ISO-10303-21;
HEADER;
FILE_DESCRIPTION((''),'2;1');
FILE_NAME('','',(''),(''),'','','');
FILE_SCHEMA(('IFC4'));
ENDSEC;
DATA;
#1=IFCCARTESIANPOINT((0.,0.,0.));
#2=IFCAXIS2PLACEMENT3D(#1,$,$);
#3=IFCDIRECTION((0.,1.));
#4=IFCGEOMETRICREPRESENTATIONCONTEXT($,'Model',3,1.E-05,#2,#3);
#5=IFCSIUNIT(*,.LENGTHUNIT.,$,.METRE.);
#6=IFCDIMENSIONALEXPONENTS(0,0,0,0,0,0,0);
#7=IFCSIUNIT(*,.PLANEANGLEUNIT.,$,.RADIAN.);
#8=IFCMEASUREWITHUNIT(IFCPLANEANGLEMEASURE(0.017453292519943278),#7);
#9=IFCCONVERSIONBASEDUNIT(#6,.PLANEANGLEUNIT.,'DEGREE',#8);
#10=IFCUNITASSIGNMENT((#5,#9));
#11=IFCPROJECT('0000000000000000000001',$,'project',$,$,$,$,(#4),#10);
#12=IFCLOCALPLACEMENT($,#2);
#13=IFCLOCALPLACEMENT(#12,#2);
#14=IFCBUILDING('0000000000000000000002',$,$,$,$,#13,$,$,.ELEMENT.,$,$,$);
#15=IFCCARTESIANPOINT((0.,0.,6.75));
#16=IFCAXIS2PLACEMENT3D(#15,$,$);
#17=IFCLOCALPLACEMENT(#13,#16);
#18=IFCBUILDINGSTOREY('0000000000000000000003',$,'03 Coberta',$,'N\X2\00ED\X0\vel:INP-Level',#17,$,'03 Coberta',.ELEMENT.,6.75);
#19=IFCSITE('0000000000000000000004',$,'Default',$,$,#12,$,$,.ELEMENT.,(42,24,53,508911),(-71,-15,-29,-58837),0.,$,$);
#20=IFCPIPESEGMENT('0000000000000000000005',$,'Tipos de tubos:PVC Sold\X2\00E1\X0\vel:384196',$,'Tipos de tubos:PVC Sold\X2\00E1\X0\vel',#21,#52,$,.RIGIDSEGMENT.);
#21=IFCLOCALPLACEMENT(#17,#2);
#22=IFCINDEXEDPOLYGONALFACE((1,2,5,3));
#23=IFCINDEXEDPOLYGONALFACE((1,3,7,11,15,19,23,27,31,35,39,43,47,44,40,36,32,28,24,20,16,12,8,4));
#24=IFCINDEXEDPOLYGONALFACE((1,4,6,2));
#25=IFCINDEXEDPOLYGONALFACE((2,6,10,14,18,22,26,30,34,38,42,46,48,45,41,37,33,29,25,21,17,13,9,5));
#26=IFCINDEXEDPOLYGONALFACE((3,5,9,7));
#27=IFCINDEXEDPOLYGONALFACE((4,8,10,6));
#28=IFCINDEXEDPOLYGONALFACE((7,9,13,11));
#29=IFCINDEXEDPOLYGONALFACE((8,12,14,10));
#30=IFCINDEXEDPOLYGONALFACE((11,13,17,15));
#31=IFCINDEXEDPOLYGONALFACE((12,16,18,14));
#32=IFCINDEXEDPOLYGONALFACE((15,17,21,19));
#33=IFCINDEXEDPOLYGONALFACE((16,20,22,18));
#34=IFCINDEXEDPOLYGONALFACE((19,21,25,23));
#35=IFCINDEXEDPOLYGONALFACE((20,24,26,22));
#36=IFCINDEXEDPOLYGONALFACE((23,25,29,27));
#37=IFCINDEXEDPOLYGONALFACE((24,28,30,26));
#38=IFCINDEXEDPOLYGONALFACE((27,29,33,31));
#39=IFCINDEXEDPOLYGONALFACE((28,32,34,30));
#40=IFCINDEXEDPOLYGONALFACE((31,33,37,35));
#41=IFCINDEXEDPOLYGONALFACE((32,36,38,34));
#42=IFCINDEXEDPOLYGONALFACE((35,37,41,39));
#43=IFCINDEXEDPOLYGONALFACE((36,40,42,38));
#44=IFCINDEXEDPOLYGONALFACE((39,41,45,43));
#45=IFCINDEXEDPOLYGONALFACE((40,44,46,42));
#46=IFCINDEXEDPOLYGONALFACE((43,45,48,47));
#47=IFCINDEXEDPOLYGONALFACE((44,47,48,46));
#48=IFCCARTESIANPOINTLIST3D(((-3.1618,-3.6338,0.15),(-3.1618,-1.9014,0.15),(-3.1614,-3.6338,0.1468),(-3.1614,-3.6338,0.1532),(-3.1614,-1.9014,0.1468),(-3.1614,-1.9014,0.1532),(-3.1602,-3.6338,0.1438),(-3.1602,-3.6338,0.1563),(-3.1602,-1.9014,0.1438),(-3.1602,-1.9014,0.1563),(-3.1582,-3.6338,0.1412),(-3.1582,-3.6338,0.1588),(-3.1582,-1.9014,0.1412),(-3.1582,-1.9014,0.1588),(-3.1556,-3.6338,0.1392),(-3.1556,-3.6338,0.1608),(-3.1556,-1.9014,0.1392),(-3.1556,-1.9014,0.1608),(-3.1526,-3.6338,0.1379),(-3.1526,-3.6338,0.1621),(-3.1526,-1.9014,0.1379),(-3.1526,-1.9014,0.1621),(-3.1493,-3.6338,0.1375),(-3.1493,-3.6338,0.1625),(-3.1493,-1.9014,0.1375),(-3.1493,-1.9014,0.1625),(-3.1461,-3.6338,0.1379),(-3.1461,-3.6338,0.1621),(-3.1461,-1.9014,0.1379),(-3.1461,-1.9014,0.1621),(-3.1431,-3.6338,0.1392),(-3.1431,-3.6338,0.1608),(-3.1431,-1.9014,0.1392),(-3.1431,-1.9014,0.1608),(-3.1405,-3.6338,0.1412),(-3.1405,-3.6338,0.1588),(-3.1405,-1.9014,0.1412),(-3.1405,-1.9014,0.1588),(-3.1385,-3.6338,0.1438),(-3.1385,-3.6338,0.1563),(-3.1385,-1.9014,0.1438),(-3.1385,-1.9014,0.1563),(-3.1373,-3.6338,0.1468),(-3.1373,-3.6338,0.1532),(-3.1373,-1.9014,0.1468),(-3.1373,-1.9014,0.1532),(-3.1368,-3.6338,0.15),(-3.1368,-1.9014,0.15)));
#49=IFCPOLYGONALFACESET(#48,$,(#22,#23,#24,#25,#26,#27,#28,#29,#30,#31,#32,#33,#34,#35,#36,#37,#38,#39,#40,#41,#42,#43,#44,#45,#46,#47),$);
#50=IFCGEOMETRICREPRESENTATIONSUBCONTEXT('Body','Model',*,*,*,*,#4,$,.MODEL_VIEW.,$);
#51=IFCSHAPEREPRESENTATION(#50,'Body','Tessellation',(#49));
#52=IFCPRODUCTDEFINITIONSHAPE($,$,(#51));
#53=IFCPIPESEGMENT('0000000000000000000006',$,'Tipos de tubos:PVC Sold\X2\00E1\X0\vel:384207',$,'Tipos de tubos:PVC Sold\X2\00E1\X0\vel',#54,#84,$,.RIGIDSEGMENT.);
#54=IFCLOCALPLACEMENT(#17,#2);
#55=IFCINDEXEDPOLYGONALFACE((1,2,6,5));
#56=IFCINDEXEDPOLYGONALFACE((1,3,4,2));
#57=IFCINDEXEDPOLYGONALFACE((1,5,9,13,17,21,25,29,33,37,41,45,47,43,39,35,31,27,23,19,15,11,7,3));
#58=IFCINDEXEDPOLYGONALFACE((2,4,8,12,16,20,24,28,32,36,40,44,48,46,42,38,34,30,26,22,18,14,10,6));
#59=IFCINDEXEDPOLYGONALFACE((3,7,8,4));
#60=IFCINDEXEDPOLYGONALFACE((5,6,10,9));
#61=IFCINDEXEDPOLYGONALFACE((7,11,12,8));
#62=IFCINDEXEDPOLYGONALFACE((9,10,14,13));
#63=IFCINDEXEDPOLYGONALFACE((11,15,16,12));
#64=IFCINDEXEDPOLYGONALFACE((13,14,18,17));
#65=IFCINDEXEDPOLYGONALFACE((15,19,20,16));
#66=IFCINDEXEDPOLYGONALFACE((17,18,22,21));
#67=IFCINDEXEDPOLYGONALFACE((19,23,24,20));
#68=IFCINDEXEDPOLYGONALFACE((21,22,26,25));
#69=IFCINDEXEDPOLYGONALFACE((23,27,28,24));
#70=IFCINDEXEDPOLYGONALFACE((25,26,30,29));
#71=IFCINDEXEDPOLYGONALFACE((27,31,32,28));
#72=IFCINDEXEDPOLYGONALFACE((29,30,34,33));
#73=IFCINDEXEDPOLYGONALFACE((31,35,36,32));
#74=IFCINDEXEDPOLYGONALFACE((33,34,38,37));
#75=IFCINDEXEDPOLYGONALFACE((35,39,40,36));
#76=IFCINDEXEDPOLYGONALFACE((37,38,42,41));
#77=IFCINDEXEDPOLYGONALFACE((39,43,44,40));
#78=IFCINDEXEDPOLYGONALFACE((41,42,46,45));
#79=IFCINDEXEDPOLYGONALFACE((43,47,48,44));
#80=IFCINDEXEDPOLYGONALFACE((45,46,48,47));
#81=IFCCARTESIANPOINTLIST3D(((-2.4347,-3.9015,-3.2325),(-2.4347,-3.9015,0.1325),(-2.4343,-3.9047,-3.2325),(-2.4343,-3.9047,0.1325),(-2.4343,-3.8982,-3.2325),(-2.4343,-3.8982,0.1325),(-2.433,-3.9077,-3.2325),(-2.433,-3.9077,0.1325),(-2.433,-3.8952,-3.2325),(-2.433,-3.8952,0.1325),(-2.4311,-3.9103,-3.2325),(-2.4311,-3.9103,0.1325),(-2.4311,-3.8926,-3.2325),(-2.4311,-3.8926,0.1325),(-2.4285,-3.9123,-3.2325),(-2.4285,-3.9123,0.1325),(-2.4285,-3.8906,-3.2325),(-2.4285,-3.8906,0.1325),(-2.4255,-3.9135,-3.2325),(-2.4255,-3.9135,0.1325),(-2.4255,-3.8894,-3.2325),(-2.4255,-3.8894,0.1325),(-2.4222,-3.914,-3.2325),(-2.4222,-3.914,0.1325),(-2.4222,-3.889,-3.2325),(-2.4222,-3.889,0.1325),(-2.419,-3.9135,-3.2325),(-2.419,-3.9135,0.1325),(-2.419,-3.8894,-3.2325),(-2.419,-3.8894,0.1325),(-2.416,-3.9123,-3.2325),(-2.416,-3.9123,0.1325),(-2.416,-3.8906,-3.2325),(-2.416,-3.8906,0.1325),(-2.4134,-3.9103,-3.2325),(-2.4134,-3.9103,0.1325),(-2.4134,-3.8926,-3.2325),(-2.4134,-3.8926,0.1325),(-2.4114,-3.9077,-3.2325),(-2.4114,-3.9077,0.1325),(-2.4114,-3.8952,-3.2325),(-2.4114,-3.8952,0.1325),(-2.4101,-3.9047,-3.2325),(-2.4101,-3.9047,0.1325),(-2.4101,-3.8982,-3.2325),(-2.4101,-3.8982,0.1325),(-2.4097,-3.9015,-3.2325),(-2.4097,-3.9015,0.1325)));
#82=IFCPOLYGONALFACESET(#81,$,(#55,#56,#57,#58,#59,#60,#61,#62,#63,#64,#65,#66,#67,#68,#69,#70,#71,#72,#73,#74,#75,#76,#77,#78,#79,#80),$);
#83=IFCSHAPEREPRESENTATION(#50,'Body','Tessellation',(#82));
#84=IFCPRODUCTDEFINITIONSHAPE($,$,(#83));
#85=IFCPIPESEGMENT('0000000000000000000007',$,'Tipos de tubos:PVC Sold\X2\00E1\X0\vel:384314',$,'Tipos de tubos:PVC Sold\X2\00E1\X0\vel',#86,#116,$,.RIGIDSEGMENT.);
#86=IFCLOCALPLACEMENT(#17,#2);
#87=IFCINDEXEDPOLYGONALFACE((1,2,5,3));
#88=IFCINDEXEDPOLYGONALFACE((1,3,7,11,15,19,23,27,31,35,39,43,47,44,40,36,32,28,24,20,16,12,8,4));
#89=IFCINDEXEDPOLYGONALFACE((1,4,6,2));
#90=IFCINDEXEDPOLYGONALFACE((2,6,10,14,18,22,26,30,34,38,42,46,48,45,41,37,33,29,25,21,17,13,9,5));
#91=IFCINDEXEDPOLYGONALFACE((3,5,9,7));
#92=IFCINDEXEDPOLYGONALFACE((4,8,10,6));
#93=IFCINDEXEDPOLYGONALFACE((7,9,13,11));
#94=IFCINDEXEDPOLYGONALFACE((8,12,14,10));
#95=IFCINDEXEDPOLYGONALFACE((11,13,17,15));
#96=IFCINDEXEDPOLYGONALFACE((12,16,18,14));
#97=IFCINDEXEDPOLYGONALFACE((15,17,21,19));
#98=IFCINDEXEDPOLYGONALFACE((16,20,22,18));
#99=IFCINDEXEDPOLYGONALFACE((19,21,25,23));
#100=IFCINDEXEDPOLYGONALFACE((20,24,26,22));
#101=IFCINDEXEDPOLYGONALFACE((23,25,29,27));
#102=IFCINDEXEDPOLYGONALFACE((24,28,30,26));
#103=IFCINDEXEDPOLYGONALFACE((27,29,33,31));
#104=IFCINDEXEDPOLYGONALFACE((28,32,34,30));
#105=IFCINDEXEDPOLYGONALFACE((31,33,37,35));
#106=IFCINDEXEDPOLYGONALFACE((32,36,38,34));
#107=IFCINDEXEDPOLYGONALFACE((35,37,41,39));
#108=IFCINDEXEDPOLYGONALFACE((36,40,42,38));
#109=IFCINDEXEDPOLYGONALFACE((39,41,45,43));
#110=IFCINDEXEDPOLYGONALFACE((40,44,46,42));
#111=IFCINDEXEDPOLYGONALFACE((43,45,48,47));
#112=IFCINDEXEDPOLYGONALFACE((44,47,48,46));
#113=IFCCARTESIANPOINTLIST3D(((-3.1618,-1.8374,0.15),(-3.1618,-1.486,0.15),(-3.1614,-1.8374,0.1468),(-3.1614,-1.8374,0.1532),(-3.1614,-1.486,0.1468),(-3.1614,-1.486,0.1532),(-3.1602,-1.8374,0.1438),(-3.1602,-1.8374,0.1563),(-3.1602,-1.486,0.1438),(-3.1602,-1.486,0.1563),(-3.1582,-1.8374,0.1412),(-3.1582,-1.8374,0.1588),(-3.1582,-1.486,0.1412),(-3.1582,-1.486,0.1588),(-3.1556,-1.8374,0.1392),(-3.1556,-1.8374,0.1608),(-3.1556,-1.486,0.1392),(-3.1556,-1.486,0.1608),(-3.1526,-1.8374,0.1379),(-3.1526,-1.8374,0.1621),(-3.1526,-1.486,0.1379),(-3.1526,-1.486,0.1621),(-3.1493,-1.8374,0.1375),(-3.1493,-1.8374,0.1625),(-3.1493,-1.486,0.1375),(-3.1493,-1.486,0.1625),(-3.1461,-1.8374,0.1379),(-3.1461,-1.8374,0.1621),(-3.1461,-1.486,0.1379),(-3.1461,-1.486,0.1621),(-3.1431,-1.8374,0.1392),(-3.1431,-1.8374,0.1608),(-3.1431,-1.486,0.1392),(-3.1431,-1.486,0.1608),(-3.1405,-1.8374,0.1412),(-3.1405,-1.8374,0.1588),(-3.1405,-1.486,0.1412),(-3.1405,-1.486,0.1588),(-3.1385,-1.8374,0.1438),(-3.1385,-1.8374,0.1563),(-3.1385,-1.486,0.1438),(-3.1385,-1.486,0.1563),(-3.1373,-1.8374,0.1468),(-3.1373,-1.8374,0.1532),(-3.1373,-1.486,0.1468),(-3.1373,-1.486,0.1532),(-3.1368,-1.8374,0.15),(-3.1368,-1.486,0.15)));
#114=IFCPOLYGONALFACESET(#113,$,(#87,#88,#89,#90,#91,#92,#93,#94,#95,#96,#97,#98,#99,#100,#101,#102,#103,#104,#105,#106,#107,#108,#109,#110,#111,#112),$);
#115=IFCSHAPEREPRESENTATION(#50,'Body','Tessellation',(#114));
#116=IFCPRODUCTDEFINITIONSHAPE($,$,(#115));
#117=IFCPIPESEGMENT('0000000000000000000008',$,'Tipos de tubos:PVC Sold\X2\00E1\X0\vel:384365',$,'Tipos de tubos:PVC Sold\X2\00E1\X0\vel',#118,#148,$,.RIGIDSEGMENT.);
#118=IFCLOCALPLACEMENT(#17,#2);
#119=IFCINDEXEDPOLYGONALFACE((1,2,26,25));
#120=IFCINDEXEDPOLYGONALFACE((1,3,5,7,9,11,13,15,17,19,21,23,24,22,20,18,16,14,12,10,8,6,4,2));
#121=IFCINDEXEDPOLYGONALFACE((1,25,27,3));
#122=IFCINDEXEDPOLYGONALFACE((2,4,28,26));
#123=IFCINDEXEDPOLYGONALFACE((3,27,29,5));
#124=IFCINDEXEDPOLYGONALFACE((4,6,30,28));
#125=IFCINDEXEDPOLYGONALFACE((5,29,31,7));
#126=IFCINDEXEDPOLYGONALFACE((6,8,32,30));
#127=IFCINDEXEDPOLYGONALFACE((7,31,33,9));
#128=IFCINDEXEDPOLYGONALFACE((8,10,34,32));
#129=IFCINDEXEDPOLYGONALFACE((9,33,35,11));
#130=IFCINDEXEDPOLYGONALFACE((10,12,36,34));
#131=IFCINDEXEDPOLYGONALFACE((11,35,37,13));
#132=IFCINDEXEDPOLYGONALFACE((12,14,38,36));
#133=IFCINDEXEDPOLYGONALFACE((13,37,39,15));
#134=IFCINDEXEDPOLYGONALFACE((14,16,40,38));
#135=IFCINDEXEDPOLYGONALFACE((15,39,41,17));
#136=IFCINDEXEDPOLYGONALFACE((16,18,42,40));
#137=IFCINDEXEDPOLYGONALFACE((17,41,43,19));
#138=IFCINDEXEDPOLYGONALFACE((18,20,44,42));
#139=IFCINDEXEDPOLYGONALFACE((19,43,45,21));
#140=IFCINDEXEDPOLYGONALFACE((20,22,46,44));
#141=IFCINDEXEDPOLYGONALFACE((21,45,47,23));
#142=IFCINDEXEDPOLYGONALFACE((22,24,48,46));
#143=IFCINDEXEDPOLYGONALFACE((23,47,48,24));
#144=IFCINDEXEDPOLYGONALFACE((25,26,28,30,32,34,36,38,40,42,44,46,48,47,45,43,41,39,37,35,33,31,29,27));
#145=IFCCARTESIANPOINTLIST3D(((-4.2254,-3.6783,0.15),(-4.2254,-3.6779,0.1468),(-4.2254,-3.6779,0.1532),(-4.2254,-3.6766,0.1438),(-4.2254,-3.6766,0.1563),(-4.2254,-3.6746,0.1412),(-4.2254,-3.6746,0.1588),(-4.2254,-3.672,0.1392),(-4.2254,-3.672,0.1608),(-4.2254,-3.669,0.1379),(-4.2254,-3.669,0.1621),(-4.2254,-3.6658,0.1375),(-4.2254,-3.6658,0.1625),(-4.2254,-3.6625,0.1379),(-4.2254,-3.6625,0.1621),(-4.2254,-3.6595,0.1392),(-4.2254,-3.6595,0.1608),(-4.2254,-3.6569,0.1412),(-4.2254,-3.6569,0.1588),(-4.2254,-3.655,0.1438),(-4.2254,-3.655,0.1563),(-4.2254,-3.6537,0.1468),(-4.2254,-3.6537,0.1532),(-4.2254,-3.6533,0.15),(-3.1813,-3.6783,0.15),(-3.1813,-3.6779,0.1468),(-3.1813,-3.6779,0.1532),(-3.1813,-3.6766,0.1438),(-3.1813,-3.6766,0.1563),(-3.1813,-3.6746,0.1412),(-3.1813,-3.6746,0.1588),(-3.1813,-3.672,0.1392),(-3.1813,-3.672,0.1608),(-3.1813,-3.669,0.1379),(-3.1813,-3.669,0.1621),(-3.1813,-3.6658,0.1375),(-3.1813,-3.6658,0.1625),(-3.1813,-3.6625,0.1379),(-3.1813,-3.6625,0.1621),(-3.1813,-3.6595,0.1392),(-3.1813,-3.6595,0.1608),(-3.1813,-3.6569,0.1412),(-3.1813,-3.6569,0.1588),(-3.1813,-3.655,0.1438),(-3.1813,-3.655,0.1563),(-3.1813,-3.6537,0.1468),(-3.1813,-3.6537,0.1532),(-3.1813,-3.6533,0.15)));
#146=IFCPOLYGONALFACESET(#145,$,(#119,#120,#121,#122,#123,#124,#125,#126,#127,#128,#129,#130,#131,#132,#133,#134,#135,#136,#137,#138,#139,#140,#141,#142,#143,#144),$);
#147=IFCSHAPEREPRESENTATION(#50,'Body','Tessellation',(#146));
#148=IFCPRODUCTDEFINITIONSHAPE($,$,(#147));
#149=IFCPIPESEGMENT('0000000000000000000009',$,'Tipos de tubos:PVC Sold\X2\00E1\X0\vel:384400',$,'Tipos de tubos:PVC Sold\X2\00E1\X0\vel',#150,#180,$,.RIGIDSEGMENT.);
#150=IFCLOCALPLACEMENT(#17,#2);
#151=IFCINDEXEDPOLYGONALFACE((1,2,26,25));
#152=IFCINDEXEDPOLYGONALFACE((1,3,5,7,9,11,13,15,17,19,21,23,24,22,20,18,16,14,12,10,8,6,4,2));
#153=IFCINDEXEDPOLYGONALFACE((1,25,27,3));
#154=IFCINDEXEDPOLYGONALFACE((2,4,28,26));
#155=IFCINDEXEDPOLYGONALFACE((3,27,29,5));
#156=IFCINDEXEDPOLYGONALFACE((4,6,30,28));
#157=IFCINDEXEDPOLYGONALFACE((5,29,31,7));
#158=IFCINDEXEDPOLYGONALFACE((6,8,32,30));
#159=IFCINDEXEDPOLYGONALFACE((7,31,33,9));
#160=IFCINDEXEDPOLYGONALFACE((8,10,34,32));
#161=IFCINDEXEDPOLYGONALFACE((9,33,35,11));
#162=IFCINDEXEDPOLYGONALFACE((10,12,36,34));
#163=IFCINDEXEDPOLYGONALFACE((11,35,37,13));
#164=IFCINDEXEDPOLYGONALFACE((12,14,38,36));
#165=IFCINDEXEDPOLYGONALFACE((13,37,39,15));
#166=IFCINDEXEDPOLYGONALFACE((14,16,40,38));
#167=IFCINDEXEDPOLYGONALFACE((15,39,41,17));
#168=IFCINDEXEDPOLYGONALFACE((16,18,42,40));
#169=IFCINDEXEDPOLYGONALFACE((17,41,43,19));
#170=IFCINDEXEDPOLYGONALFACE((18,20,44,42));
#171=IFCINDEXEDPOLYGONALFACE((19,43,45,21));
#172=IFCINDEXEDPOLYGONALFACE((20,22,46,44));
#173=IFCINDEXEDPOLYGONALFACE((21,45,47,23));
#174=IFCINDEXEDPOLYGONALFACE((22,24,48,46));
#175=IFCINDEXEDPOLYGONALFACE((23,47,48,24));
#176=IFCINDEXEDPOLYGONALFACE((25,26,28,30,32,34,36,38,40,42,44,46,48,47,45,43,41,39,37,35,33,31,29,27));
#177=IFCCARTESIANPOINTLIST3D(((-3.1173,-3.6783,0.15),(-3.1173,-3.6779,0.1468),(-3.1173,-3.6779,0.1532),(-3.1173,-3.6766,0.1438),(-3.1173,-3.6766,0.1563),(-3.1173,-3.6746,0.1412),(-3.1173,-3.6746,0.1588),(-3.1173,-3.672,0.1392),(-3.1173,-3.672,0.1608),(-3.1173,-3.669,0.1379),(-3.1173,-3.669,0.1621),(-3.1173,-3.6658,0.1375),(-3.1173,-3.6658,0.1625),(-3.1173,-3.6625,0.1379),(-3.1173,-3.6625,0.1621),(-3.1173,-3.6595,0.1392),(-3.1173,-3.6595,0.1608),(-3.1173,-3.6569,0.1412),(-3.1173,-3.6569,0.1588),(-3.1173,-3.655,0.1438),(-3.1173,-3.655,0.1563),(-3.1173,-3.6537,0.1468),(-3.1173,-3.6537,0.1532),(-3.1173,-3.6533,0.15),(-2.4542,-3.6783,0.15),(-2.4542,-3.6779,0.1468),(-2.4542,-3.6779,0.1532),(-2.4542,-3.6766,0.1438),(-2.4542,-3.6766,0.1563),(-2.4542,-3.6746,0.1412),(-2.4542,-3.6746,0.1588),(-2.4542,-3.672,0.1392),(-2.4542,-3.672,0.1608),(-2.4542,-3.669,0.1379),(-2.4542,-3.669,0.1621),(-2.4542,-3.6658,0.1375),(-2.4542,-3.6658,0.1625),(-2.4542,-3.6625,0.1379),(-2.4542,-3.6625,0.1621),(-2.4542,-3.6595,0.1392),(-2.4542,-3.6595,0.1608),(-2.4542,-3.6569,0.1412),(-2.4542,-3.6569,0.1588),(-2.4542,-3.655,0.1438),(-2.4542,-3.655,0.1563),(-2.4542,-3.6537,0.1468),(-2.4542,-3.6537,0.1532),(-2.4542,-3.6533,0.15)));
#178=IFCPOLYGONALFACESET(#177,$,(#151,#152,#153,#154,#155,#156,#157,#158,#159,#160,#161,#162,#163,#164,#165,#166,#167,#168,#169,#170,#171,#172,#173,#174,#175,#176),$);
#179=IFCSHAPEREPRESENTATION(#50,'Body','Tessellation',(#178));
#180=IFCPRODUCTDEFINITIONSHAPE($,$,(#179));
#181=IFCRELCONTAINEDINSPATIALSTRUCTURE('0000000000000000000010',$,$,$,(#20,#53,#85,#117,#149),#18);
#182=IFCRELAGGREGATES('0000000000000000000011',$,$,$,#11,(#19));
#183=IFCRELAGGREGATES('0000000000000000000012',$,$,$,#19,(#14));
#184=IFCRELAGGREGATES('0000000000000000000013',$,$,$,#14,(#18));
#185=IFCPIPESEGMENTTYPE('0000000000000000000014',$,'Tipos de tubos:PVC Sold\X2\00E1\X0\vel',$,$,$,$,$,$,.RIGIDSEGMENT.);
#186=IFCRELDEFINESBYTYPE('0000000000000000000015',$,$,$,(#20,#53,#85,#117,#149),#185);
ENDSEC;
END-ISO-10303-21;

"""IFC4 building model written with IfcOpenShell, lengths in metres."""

from ifc_helpers import new_model, entity, si_unit, converted_unit, direction, frame, origin, place, context, subcontext, project, spatial, arc, indexed_curve, outline, extrude, type_object, element, save


model = new_model("IFC4")

# Units and contexts
model_context = context("Model", 3, precision=1e-05, world=origin(), true_north=direction((0.0, 1.0)))
body_context = subcontext(model_context, "Body", "Model", "MODEL_VIEW")
ifc_project = project(units=[si_unit("LENGTHUNIT", "METRE"), converted_unit("PLANEANGLEUNIT", "DEGREE", entity("IfcPlaneAngleMeasure", 0.017453292519943278), si_unit("PLANEANGLEUNIT", "RADIAN"), dimensions=[0, 0, 0, 0, 0, 0, 0])], contexts=[model_context])

# Site, building, storey
site_placement = place(None, origin())
site = spatial("IfcSite", under=ifc_project, at=site_placement, Name="Default", CompositionType="ELEMENT", RefLatitude=(42, 24, 53, 508911), RefLongitude=(-71, -15, -29, -58837), RefElevation=0.0)
building_placement = place(site_placement, origin())
building = spatial("IfcBuilding", under=site, at=building_placement, CompositionType="ELEMENT")
storey_placement = place(building_placement, frame((0.0, 0.0, 6.75)))
storey = spatial("IfcBuildingStorey", under=building, at=storey_placement, Name="03 Coberta", ObjectType="Nível:INP-Level", LongName="03 Coberta", CompositionType="ELEMENT", Elevation=6.75)

# Pipe segments
pipe_segment_type = type_object("IfcPipeSegmentType", Name="Tipos de tubos:PVC Soldável", PredefinedType="RIGIDSEGMENT")
pipe_segment_1_placement = place(storey_placement, origin())
element("IfcPipeSegment", 1, at=pipe_segment_1_placement, inside=storey, type_object=pipe_segment_type, Name="Tipos de tubos:PVC Soldável:384196", ObjectType="Tipos de tubos:PVC Soldável", PredefinedType="RIGIDSEGMENT", context=body_context, shape_type="SweptSolid", body=[
    extrude(outline(indexed_curve([(0.0125, 0.0), (0.0088, 0.0088), (0.0, 0.0125), (-0.0088, 0.0088), (-0.0125, 0.0), (-0.0088, -0.0088), (0.0, -0.0125), (0.0088, -0.0088)], segments=[arc(1, 2, 3), arc(3, 4, 5), arc(5, 6, 7), arc(7, 8, 1)], self_intersect=False)), frame((-3.1493, -3.6338, 0.15), z_axis=(0.0, 1.0, 0.0), x_axis=(-1.0, 0.0, 0.0)), (0.0, 0.0, 1.0), 1.7323),
])
pipe_segment_2_placement = place(storey_placement, origin())
element("IfcPipeSegment", 2, at=pipe_segment_2_placement, inside=storey, type_object=pipe_segment_type, Name="Tipos de tubos:PVC Soldável:384207", ObjectType="Tipos de tubos:PVC Soldável", PredefinedType="RIGIDSEGMENT", context=body_context, shape_type="SweptSolid", body=[
    extrude(outline(indexed_curve([(0.0125, 0.0), (0.0088, 0.0088), (0.0, 0.0125), (-0.0088, 0.0088), (-0.0125, 0.0), (-0.0088, -0.0088), (0.0, -0.0125), (0.0088, -0.0088)], segments=[arc(1, 2, 3), arc(3, 4, 5), arc(5, 6, 7), arc(7, 8, 1)], self_intersect=False)), frame((-2.4222, -3.9015, -3.2325)), (0.0, 0.0, 1.0), 3.365),
])
pipe_segment_3_placement = place(storey_placement, origin())
element("IfcPipeSegment", 3, at=pipe_segment_3_placement, inside=storey, type_object=pipe_segment_type, Name="Tipos de tubos:PVC Soldável:384314", ObjectType="Tipos de tubos:PVC Soldável", PredefinedType="RIGIDSEGMENT", context=body_context, shape_type="SweptSolid", body=[
    extrude(outline(indexed_curve([(0.0125, 0.0), (0.0088, 0.0088), (0.0, 0.0125), (-0.0088, 0.0088), (-0.0125, 0.0), (-0.0088, -0.0088), (0.0, -0.0125), (0.0088, -0.0088)], segments=[arc(1, 2, 3), arc(3, 4, 5), arc(5, 6, 7), arc(7, 8, 1)], self_intersect=False)), frame((-3.1493, -1.8374, 0.15), z_axis=(0.0, 1.0, 0.0), x_axis=(-1.0, 0.0, 0.0)), (0.0, 0.0, 1.0), 0.3514),
])
pipe_segment_4_placement = place(storey_placement, origin())
element("IfcPipeSegment", 4, at=pipe_segment_4_placement, inside=storey, type_object=pipe_segment_type, Name="Tipos de tubos:PVC Soldável:384365", ObjectType="Tipos de tubos:PVC Soldável", PredefinedType="RIGIDSEGMENT", context=body_context, shape_type="SweptSolid", body=[
    extrude(outline(indexed_curve([(0.0125, 0.0), (0.0088, 0.0088), (0.0, 0.0125), (-0.0088, 0.0088), (-0.0125, 0.0), (-0.0088, -0.0088), (0.0, -0.0125), (0.0088, -0.0088)], segments=[arc(1, 2, 3), arc(3, 4, 5), arc(5, 6, 7), arc(7, 8, 1)], self_intersect=False)), frame((-4.2254, -3.6658, 0.15), z_axis=(1.0, 0.0, 0.0), x_axis=(0.0, -1.0, 0.0)), (0.0, 0.0, 1.0), 1.044),
])
pipe_segment_5_placement = place(storey_placement, origin())
element("IfcPipeSegment", 5, at=pipe_segment_5_placement, inside=storey, type_object=pipe_segment_type, Name="Tipos de tubos:PVC Soldável:384400", ObjectType="Tipos de tubos:PVC Soldável", PredefinedType="RIGIDSEGMENT", context=body_context, shape_type="SweptSolid", body=[
    extrude(outline(indexed_curve([(0.0125, 0.0), (0.0088, 0.0088), (0.0, 0.0125), (-0.0088, 0.0088), (-0.0125, 0.0), (-0.0088, -0.0088), (0.0, -0.0125), (0.0088, -0.0088)], segments=[arc(1, 2, 3), arc(3, 4, 5), arc(5, 6, 7), arc(7, 8, 1)], self_intersect=False)), frame((-3.1173, -3.6658, 0.15), z_axis=(1.0, 0.0, 0.0), x_axis=(0.0, -1.0, 0.0)), (0.0, 0.0, 1.0), 0.6631),
])

save(model, "model.ifc")
